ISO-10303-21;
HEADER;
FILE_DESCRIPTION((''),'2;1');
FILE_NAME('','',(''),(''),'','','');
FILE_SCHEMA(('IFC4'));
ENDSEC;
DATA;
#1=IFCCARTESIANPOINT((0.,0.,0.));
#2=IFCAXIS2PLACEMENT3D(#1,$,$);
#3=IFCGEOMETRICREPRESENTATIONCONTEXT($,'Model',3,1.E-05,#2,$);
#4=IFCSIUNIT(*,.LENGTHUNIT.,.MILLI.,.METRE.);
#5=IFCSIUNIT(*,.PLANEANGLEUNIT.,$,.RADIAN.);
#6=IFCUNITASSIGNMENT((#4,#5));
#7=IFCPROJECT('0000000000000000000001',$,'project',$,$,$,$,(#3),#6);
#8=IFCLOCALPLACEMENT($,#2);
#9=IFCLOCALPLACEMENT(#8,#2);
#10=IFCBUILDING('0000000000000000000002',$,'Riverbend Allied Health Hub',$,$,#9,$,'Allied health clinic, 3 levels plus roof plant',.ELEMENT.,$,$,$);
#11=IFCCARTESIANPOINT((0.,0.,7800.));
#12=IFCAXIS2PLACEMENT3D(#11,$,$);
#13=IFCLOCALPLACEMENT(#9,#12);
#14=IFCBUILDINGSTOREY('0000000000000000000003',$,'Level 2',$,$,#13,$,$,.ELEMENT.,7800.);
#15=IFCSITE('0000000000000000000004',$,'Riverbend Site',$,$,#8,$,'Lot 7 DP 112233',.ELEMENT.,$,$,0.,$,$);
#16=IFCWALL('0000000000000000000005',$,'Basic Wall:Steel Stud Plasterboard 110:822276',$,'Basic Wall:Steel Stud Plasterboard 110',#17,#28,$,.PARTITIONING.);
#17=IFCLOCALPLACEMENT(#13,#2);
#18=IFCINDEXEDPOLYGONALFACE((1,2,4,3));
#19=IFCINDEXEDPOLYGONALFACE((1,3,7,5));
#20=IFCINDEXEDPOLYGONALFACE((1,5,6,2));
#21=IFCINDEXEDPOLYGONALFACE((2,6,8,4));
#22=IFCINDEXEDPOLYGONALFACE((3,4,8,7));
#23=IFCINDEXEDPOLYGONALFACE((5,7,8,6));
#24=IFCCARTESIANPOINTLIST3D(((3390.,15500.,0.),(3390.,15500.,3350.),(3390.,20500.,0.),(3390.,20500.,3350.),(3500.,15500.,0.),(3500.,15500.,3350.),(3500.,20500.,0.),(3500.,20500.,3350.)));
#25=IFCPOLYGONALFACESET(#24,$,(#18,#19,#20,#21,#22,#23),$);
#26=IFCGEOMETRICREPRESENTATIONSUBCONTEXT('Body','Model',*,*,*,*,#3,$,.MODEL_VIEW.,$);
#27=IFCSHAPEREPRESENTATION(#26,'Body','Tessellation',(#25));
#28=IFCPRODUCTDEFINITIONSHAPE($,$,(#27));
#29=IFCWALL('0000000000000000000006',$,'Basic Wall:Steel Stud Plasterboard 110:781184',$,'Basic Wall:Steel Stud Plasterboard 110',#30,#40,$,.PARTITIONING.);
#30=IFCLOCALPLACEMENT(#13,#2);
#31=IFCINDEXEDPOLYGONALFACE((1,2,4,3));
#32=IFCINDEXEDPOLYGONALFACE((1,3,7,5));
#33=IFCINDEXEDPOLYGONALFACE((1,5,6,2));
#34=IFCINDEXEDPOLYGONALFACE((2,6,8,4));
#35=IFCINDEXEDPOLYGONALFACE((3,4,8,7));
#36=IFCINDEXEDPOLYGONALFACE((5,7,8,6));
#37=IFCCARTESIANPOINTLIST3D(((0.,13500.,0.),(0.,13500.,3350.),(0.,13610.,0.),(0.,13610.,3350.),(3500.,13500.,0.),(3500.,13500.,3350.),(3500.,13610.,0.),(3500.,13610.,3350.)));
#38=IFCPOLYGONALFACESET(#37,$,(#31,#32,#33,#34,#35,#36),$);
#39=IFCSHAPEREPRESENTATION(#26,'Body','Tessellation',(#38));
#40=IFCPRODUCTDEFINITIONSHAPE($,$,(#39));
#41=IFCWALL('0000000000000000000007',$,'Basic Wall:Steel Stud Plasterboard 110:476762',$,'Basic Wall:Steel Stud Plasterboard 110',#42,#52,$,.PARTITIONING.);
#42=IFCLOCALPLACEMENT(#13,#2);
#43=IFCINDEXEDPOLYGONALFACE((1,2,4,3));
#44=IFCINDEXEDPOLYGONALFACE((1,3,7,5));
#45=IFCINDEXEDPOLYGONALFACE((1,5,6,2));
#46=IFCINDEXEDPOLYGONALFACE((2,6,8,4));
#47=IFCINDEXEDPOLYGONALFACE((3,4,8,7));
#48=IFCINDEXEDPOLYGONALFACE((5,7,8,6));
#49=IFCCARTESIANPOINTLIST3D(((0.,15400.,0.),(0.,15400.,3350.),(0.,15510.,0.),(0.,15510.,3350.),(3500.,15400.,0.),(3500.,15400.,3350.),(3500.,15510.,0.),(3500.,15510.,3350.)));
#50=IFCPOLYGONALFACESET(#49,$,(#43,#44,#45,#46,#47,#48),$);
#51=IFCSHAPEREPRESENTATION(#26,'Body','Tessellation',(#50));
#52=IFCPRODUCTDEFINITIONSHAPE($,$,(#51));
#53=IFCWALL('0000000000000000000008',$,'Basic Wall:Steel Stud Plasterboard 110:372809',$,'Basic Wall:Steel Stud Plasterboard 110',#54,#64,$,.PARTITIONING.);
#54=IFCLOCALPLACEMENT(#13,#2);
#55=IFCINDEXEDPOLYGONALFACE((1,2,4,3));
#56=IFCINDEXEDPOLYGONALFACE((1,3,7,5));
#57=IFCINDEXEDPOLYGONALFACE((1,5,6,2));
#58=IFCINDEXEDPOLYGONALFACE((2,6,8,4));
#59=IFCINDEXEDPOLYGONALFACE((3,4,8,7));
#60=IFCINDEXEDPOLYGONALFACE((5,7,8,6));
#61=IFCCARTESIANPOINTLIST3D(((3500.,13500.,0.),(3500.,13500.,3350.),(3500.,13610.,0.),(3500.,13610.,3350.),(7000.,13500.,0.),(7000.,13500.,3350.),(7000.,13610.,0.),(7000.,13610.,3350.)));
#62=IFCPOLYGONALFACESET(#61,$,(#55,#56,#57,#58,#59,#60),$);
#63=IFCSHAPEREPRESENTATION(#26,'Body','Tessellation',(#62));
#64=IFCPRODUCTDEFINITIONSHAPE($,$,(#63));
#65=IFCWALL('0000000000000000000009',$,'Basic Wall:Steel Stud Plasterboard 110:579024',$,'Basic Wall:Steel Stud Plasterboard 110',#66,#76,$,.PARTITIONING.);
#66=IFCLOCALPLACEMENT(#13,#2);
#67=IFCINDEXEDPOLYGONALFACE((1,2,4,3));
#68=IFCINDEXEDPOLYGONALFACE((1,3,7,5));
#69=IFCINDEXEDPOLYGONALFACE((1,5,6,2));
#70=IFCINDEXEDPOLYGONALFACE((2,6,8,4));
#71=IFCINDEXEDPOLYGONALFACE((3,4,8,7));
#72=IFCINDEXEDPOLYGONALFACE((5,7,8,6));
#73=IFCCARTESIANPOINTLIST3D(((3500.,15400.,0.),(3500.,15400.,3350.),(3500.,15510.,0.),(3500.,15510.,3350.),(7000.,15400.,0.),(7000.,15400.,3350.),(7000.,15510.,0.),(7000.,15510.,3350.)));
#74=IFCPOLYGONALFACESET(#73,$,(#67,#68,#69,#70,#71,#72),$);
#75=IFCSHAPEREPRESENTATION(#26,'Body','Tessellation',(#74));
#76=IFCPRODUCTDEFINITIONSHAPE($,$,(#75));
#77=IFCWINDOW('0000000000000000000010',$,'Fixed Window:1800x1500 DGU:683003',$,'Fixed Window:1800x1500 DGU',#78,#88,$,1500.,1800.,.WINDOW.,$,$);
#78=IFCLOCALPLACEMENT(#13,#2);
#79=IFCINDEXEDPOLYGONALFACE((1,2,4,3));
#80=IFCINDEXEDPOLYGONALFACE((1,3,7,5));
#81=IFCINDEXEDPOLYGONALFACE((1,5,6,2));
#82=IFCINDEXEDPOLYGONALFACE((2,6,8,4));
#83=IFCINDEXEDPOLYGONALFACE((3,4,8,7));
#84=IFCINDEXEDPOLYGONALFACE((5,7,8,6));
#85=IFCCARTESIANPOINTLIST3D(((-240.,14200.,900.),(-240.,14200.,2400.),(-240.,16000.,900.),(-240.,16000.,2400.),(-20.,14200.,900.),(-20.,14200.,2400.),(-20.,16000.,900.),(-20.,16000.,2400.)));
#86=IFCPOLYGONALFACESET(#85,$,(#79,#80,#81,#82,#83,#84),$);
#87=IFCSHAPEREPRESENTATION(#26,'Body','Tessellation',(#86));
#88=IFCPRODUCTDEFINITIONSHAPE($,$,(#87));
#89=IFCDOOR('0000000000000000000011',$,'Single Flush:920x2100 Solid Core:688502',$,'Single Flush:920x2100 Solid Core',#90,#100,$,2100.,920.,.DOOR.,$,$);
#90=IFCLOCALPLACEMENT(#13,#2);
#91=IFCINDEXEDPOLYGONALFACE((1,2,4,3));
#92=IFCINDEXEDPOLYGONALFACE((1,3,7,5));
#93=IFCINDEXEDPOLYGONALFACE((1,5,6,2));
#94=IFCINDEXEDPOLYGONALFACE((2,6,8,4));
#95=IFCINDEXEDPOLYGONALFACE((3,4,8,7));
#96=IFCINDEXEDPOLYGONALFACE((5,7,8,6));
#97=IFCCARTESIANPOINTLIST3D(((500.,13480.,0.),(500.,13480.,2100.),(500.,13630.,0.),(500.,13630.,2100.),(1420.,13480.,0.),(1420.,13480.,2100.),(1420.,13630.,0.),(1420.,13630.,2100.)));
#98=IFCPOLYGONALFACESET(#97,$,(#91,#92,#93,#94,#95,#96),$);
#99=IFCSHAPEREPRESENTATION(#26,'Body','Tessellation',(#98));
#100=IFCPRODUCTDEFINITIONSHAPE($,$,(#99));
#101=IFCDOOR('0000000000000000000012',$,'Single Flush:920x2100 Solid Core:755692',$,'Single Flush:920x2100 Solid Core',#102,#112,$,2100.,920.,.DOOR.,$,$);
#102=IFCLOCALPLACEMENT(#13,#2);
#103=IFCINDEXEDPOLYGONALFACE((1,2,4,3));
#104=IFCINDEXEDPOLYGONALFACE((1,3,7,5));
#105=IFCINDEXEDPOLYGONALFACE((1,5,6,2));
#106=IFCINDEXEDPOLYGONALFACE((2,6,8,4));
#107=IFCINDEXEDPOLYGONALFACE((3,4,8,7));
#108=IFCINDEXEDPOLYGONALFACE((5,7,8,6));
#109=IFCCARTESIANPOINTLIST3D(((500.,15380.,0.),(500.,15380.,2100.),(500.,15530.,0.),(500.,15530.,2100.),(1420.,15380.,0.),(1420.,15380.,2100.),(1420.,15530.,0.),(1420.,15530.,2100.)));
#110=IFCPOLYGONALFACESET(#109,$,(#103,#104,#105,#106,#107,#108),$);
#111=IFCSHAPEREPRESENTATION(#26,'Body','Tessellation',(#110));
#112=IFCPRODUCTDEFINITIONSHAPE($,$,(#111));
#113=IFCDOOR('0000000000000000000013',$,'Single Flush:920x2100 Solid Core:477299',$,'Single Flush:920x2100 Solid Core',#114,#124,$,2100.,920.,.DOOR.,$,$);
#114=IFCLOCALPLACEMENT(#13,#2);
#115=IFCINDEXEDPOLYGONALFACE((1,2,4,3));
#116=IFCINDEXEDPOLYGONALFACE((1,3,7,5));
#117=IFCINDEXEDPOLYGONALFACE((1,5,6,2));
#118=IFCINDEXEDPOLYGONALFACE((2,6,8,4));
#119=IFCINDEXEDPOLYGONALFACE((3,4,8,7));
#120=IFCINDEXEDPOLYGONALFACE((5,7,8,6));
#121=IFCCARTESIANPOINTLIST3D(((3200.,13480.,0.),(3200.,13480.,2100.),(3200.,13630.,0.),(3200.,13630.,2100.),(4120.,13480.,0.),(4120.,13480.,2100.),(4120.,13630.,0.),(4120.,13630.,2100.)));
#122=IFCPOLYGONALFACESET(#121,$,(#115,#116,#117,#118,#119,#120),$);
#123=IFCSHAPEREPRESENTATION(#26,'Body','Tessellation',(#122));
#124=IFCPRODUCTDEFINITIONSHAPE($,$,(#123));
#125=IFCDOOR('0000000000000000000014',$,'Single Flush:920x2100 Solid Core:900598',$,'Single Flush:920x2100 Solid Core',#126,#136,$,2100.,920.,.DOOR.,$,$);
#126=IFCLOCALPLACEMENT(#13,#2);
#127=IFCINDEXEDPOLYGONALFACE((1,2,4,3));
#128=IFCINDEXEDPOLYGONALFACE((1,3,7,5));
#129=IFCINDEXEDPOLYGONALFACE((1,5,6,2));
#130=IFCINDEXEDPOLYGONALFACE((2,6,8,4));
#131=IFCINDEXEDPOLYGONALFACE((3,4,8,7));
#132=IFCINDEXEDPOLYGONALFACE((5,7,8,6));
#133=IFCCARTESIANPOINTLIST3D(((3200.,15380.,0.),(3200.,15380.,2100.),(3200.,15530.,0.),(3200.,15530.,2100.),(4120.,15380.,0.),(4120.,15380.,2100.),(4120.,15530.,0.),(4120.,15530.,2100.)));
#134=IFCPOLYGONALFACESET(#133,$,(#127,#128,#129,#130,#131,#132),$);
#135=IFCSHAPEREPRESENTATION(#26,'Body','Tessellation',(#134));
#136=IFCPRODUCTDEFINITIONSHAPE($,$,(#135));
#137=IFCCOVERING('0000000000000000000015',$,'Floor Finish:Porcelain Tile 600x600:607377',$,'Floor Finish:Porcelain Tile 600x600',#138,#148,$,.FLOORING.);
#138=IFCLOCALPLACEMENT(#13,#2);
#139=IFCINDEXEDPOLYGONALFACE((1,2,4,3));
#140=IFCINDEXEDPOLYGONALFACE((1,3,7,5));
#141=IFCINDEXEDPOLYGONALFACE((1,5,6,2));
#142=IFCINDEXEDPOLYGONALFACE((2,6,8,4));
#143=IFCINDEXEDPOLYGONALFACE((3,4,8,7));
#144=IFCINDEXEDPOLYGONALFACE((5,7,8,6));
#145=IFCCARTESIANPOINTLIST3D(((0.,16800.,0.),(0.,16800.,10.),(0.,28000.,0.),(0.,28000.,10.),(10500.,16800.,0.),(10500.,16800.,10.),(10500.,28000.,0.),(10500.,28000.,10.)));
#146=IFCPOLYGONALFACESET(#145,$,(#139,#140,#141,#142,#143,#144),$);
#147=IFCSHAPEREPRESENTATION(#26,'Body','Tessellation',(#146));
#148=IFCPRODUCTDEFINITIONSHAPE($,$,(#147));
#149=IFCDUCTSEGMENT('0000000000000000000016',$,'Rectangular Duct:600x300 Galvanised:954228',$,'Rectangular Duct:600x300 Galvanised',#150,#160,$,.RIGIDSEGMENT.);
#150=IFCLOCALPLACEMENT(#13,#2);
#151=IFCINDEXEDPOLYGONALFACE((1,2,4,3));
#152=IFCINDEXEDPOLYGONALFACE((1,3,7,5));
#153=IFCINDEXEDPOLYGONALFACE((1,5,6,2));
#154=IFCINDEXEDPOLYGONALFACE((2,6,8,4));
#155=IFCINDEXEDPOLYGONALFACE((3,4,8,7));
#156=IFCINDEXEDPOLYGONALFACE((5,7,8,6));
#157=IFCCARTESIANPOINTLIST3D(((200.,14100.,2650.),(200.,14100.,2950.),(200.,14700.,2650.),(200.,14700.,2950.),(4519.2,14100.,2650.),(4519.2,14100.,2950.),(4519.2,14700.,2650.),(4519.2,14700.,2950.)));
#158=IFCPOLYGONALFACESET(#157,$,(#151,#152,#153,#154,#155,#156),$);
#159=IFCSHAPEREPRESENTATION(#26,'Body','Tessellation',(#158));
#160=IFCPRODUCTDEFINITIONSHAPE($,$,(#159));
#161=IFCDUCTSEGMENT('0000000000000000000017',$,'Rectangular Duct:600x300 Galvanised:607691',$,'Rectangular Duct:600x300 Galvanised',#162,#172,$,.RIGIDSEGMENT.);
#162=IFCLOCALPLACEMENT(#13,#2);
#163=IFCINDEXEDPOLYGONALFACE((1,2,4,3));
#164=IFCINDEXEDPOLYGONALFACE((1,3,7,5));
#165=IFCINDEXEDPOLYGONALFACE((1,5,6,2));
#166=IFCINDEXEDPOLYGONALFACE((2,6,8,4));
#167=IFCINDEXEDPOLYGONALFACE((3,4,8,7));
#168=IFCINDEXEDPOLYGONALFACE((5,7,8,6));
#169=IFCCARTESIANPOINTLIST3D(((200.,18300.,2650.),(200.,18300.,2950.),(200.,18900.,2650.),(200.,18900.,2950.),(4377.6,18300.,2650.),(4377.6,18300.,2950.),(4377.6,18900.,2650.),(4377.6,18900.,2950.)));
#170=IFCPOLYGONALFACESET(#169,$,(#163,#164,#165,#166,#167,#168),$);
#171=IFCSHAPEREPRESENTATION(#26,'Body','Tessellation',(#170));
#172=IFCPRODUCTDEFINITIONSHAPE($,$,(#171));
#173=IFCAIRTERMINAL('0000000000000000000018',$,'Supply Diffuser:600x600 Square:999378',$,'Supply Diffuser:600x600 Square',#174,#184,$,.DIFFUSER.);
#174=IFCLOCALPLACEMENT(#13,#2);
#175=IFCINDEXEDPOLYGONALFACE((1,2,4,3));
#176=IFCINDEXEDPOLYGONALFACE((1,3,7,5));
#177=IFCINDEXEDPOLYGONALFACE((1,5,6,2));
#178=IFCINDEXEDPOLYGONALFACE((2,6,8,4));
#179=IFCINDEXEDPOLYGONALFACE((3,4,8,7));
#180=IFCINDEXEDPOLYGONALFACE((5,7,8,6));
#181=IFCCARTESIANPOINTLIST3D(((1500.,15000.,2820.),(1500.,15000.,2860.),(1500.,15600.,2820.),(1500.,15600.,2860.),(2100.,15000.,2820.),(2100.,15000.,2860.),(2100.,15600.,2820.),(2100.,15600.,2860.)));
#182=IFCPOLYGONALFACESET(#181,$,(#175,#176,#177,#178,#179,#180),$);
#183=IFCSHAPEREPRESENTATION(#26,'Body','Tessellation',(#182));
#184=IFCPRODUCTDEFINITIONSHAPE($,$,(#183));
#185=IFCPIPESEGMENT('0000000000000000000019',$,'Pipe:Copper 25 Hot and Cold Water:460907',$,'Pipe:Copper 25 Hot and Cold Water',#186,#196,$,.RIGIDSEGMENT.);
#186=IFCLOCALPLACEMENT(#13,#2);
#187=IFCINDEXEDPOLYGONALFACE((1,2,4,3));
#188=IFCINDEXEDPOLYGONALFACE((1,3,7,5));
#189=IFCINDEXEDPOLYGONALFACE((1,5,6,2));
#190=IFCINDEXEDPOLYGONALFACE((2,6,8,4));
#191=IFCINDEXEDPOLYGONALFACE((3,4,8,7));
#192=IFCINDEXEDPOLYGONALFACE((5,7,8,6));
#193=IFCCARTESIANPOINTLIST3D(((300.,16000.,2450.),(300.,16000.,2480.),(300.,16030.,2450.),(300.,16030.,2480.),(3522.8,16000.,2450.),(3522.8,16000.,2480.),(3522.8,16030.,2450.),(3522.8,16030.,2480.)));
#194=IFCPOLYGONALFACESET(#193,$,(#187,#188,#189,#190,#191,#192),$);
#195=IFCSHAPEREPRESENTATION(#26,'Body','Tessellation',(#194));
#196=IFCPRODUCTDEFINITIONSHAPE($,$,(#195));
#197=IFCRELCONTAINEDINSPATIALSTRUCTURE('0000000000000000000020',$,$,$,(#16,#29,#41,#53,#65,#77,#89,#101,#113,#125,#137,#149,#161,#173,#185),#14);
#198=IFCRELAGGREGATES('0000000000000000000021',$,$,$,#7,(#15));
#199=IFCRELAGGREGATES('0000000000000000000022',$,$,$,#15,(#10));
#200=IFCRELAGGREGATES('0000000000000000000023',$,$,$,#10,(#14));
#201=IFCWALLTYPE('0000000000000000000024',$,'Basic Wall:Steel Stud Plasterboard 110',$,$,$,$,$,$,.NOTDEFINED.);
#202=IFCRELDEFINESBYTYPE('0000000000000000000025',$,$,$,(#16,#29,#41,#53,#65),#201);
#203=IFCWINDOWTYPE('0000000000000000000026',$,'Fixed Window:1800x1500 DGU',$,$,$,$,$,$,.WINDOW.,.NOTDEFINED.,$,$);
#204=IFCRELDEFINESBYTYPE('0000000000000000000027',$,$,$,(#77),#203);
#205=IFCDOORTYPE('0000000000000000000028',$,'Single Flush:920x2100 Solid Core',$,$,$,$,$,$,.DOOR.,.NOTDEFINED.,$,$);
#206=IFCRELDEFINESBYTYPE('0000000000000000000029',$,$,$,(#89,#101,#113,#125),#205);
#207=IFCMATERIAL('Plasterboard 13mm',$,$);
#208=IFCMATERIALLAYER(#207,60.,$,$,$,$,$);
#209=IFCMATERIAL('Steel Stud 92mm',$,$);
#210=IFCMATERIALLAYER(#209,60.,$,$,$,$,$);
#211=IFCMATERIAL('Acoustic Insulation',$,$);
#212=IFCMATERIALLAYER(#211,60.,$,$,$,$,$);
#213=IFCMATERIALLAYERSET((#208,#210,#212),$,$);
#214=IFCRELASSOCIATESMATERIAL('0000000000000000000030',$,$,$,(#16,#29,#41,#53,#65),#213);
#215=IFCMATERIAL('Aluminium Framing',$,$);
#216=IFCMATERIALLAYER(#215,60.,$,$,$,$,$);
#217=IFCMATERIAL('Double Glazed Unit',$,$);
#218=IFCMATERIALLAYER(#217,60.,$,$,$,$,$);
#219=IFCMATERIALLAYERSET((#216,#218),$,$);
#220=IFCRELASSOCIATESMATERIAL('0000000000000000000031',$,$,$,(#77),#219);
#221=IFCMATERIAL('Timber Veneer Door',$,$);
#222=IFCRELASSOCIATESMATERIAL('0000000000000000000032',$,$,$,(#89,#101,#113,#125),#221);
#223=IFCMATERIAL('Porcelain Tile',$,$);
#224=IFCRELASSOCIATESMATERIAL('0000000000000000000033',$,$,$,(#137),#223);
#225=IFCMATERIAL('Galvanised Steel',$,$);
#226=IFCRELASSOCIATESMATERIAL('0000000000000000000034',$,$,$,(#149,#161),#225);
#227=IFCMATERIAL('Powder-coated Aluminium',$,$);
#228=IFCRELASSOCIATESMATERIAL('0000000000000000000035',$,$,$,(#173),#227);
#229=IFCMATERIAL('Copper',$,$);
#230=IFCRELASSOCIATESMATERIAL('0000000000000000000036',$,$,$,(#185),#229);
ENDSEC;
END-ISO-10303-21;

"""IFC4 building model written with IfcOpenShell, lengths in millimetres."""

from ifc_helpers import new_model, si_unit, frame, frame_2d, origin, place, context, subcontext, project, spatial, rectangle, extrude, material, layer, layer_set, layer_usage, type_object, element, save


model = new_model("IFC4")

# Units and contexts
model_context = context("Model", 3, precision=1e-05, world=origin())
body_context = subcontext(model_context, "Body", "Model", "MODEL_VIEW")
ifc_project = project(units=[si_unit("LENGTHUNIT", "METRE", prefix="MILLI"), si_unit("PLANEANGLEUNIT", "RADIAN")], contexts=[model_context])

# Site, building, storey
site_placement = place(None, origin())
site = spatial("IfcSite", under=ifc_project, at=site_placement, Name="Riverbend Site", LongName="Lot 7 DP 112233", CompositionType="ELEMENT", RefElevation=0.0)
building_placement = place(site_placement, origin())
building = spatial("IfcBuilding", under=site, at=building_placement, Name="Riverbend Allied Health Hub", LongName="Allied health clinic, 3 levels plus roof plant", CompositionType="ELEMENT")
storey_placement = place(building_placement, frame((0.0, 0.0, 7800.0)))
storey = spatial("IfcBuildingStorey", under=building, at=storey_placement, Name="Level 2", CompositionType="ELEMENT", Elevation=7800.0)

# Walls
ifc_material_1 = material(Name="Plasterboard 13mm")
ifc_layer_1 = layer(ifc_material_1, 60.0)
ifc_material_2 = material(Name="Steel Stud 92mm")
ifc_layer_2 = layer(ifc_material_2, 60.0)
ifc_material_3 = material(Name="Acoustic Insulation")
ifc_layer_3 = layer(ifc_material_3, 60.0)
ifc_layer_set_1 = layer_set([ifc_layer_1, ifc_layer_2, ifc_layer_3])
ifc_layer_usage_1 = layer_usage(ifc_layer_set_1, "AXIS2", "POSITIVE", 0.0)
wall_type = type_object("IfcWallType", Name="Basic Wall:Steel Stud Plasterboard 110", PredefinedType="NOTDEFINED")
wall_placement = place(storey_placement, frame((3500.0, 15500.0, 0.0), z_axis=(0.0, 0.0, 1.0), x_axis=(0.0, 1.0, 0.0)))
element("IfcWall", 1, at=wall_placement, inside=storey, type_object=wall_type, material=ifc_layer_usage_1, Name="Basic Wall:Steel Stud Plasterboard 110:822276", ObjectType="Basic Wall:Steel Stud Plasterboard 110", PredefinedType="PARTITIONING", context=body_context, shape_type="SweptSolid", body=[
    extrude(rectangle(XDim=5000.0, YDim=110.0, at=frame_2d((2500.0, 55.0))), origin(), (0.0, 0.0, 1.0), 3350.0),
])
for number, where, name in (
    (2, (0.0, 13500.0, 0.0), "Basic Wall:Steel Stud Plasterboard 110:781184"),
    (3, (0.0, 15400.0, 0.0), "Basic Wall:Steel Stud Plasterboard 110:476762"),
    (4, (3500.0, 13500.0, 0.0), "Basic Wall:Steel Stud Plasterboard 110:372809"),
    (5, (3500.0, 15400.0, 0.0), "Basic Wall:Steel Stud Plasterboard 110:579024"),
):
    element("IfcWall", number, at=place(storey_placement, frame(where)), inside=storey, type_object=wall_type, material=ifc_layer_usage_1, Name=name, ObjectType="Basic Wall:Steel Stud Plasterboard 110", PredefinedType="PARTITIONING", context=body_context, shape_type="SweptSolid", body=[
        extrude(rectangle(XDim=3500.0, YDim=110.0, at=frame_2d((1750.0, 55.0))), origin(), (0.0, 0.0, 1.0), 3350.0),
    ])

# Window
ifc_material_4 = material(Name="Aluminium Framing")
ifc_layer_4 = layer(ifc_material_4, 60.0)
ifc_material_5 = material(Name="Double Glazed Unit")
ifc_layer_5 = layer(ifc_material_5, 60.0)
ifc_layer_set_2 = layer_set([ifc_layer_4, ifc_layer_5])
ifc_layer_usage_2 = layer_usage(ifc_layer_set_2, "AXIS2", "POSITIVE", 0.0)
window_type = type_object("IfcWindowType", Name="Fixed Window:1800x1500 DGU", PartitioningType="NOTDEFINED", PredefinedType="WINDOW")
window_placement = place(storey_placement, frame((-20.0, 14200.0, 900.0), z_axis=(0.0, 0.0, 1.0), x_axis=(0.0, 1.0, 0.0)))
element("IfcWindow", 6, at=window_placement, inside=storey, type_object=window_type, material=ifc_layer_usage_2, Name="Fixed Window:1800x1500 DGU:683003", ObjectType="Fixed Window:1800x1500 DGU", OverallHeight=1500.0, OverallWidth=1800.0, PredefinedType="WINDOW", context=body_context, shape_type="SweptSolid", body=[
    extrude(rectangle(XDim=1800.0, YDim=220.0, at=frame_2d((900.0, 110.0))), origin(), (0.0, 0.0, 1.0), 1500.0),
])

# Doors
ifc_material_6 = material(Name="Timber Veneer Door")
door_type = type_object("IfcDoorType", Name="Single Flush:920x2100 Solid Core", OperationType="NOTDEFINED", PredefinedType="DOOR")
for number, where, name in (
    (7, (500.0, 13480.0, 0.0), "Single Flush:920x2100 Solid Core:688502"),
    (8, (500.0, 15380.0, 0.0), "Single Flush:920x2100 Solid Core:755692"),
    (9, (3200.0, 13480.0, 0.0), "Single Flush:920x2100 Solid Core:477299"),
    (10, (3200.0, 15380.0, 0.0), "Single Flush:920x2100 Solid Core:900598"),
):
    element("IfcDoor", number, at=place(storey_placement, frame(where)), inside=storey, type_object=door_type, material=ifc_material_6, Name=name, ObjectType="Single Flush:920x2100 Solid Core", OverallHeight=2100.0, OverallWidth=920.0, PredefinedType="DOOR", context=body_context, shape_type="SweptSolid", body=[
        extrude(rectangle(XDim=920.0, YDim=150.0, at=frame_2d((460.0, 75.0))), origin(), (0.0, 0.0, 1.0), 2100.0),
    ])

# Covering
ifc_material_7 = material(Name="Porcelain Tile")
covering_placement = place(storey_placement, frame((0.0, 16800.0, 0.0)))
element("IfcCovering", 11, at=covering_placement, inside=storey, material=ifc_material_7, Name="Floor Finish:Porcelain Tile 600x600:607377", ObjectType="Floor Finish:Porcelain Tile 600x600", PredefinedType="FLOORING", context=body_context, shape_type="SweptSolid", body=[
    extrude(rectangle(XDim=10500.0, YDim=11200.0, at=frame_2d((5250.0, 5600.0))), origin(), (0.0, 0.0, 1.0), 10.0),
])

# Duct segments
ifc_material_8 = material(Name="Galvanised Steel")
duct_segment_1_placement = place(storey_placement, frame((200.0, 14100.0, 2650.0)))
element("IfcDuctSegment", 12, at=duct_segment_1_placement, inside=storey, material=ifc_material_8, Name="Rectangular Duct:600x300 Galvanised:954228", ObjectType="Rectangular Duct:600x300 Galvanised", PredefinedType="RIGIDSEGMENT", context=body_context, shape_type="SweptSolid", body=[
    extrude(rectangle(XDim=4319.2, YDim=600.0, at=frame_2d((2159.6, 300.0))), origin(), (0.0, 0.0, 1.0), 300.0),
])
duct_segment_2_placement = place(storey_placement, frame((200.0, 18300.0, 2650.0)))
element("IfcDuctSegment", 13, at=duct_segment_2_placement, inside=storey, material=ifc_material_8, Name="Rectangular Duct:600x300 Galvanised:607691", ObjectType="Rectangular Duct:600x300 Galvanised", PredefinedType="RIGIDSEGMENT", context=body_context, shape_type="SweptSolid", body=[
    extrude(rectangle(XDim=4177.6, YDim=600.0, at=frame_2d((2088.8, 300.0))), origin(), (0.0, 0.0, 1.0), 300.0),
])

# Air terminal
ifc_material_9 = material(Name="Powder-coated Aluminium")
air_terminal_placement = place(storey_placement, frame((1500.0, 15000.0, 2820.0)))
element("IfcAirTerminal", 14, at=air_terminal_placement, inside=storey, material=ifc_material_9, Name="Supply Diffuser:600x600 Square:999378", ObjectType="Supply Diffuser:600x600 Square", PredefinedType="DIFFUSER", context=body_context, shape_type="SweptSolid", body=[
    extrude(rectangle(XDim=600.0, YDim=600.0, at=frame_2d((300.0, 300.0))), origin(), (0.0, 0.0, 1.0), 40.0),
])

# Pipe segment
ifc_material_10 = material(Name="Copper")
pipe_segment_placement = place(storey_placement, frame((300.0, 16000.0, 2450.0)))
element("IfcPipeSegment", 15, at=pipe_segment_placement, inside=storey, material=ifc_material_10, Name="Pipe:Copper 25 Hot and Cold Water:460907", ObjectType="Pipe:Copper 25 Hot and Cold Water", PredefinedType="RIGIDSEGMENT", context=body_context, shape_type="SweptSolid", body=[
    extrude(rectangle(XDim=3222.8, YDim=30.0, at=frame_2d((1611.4, 15.0))), origin(), (0.0, 0.0, 1.0), 30.0),
])

save(model, "model.ifc")
